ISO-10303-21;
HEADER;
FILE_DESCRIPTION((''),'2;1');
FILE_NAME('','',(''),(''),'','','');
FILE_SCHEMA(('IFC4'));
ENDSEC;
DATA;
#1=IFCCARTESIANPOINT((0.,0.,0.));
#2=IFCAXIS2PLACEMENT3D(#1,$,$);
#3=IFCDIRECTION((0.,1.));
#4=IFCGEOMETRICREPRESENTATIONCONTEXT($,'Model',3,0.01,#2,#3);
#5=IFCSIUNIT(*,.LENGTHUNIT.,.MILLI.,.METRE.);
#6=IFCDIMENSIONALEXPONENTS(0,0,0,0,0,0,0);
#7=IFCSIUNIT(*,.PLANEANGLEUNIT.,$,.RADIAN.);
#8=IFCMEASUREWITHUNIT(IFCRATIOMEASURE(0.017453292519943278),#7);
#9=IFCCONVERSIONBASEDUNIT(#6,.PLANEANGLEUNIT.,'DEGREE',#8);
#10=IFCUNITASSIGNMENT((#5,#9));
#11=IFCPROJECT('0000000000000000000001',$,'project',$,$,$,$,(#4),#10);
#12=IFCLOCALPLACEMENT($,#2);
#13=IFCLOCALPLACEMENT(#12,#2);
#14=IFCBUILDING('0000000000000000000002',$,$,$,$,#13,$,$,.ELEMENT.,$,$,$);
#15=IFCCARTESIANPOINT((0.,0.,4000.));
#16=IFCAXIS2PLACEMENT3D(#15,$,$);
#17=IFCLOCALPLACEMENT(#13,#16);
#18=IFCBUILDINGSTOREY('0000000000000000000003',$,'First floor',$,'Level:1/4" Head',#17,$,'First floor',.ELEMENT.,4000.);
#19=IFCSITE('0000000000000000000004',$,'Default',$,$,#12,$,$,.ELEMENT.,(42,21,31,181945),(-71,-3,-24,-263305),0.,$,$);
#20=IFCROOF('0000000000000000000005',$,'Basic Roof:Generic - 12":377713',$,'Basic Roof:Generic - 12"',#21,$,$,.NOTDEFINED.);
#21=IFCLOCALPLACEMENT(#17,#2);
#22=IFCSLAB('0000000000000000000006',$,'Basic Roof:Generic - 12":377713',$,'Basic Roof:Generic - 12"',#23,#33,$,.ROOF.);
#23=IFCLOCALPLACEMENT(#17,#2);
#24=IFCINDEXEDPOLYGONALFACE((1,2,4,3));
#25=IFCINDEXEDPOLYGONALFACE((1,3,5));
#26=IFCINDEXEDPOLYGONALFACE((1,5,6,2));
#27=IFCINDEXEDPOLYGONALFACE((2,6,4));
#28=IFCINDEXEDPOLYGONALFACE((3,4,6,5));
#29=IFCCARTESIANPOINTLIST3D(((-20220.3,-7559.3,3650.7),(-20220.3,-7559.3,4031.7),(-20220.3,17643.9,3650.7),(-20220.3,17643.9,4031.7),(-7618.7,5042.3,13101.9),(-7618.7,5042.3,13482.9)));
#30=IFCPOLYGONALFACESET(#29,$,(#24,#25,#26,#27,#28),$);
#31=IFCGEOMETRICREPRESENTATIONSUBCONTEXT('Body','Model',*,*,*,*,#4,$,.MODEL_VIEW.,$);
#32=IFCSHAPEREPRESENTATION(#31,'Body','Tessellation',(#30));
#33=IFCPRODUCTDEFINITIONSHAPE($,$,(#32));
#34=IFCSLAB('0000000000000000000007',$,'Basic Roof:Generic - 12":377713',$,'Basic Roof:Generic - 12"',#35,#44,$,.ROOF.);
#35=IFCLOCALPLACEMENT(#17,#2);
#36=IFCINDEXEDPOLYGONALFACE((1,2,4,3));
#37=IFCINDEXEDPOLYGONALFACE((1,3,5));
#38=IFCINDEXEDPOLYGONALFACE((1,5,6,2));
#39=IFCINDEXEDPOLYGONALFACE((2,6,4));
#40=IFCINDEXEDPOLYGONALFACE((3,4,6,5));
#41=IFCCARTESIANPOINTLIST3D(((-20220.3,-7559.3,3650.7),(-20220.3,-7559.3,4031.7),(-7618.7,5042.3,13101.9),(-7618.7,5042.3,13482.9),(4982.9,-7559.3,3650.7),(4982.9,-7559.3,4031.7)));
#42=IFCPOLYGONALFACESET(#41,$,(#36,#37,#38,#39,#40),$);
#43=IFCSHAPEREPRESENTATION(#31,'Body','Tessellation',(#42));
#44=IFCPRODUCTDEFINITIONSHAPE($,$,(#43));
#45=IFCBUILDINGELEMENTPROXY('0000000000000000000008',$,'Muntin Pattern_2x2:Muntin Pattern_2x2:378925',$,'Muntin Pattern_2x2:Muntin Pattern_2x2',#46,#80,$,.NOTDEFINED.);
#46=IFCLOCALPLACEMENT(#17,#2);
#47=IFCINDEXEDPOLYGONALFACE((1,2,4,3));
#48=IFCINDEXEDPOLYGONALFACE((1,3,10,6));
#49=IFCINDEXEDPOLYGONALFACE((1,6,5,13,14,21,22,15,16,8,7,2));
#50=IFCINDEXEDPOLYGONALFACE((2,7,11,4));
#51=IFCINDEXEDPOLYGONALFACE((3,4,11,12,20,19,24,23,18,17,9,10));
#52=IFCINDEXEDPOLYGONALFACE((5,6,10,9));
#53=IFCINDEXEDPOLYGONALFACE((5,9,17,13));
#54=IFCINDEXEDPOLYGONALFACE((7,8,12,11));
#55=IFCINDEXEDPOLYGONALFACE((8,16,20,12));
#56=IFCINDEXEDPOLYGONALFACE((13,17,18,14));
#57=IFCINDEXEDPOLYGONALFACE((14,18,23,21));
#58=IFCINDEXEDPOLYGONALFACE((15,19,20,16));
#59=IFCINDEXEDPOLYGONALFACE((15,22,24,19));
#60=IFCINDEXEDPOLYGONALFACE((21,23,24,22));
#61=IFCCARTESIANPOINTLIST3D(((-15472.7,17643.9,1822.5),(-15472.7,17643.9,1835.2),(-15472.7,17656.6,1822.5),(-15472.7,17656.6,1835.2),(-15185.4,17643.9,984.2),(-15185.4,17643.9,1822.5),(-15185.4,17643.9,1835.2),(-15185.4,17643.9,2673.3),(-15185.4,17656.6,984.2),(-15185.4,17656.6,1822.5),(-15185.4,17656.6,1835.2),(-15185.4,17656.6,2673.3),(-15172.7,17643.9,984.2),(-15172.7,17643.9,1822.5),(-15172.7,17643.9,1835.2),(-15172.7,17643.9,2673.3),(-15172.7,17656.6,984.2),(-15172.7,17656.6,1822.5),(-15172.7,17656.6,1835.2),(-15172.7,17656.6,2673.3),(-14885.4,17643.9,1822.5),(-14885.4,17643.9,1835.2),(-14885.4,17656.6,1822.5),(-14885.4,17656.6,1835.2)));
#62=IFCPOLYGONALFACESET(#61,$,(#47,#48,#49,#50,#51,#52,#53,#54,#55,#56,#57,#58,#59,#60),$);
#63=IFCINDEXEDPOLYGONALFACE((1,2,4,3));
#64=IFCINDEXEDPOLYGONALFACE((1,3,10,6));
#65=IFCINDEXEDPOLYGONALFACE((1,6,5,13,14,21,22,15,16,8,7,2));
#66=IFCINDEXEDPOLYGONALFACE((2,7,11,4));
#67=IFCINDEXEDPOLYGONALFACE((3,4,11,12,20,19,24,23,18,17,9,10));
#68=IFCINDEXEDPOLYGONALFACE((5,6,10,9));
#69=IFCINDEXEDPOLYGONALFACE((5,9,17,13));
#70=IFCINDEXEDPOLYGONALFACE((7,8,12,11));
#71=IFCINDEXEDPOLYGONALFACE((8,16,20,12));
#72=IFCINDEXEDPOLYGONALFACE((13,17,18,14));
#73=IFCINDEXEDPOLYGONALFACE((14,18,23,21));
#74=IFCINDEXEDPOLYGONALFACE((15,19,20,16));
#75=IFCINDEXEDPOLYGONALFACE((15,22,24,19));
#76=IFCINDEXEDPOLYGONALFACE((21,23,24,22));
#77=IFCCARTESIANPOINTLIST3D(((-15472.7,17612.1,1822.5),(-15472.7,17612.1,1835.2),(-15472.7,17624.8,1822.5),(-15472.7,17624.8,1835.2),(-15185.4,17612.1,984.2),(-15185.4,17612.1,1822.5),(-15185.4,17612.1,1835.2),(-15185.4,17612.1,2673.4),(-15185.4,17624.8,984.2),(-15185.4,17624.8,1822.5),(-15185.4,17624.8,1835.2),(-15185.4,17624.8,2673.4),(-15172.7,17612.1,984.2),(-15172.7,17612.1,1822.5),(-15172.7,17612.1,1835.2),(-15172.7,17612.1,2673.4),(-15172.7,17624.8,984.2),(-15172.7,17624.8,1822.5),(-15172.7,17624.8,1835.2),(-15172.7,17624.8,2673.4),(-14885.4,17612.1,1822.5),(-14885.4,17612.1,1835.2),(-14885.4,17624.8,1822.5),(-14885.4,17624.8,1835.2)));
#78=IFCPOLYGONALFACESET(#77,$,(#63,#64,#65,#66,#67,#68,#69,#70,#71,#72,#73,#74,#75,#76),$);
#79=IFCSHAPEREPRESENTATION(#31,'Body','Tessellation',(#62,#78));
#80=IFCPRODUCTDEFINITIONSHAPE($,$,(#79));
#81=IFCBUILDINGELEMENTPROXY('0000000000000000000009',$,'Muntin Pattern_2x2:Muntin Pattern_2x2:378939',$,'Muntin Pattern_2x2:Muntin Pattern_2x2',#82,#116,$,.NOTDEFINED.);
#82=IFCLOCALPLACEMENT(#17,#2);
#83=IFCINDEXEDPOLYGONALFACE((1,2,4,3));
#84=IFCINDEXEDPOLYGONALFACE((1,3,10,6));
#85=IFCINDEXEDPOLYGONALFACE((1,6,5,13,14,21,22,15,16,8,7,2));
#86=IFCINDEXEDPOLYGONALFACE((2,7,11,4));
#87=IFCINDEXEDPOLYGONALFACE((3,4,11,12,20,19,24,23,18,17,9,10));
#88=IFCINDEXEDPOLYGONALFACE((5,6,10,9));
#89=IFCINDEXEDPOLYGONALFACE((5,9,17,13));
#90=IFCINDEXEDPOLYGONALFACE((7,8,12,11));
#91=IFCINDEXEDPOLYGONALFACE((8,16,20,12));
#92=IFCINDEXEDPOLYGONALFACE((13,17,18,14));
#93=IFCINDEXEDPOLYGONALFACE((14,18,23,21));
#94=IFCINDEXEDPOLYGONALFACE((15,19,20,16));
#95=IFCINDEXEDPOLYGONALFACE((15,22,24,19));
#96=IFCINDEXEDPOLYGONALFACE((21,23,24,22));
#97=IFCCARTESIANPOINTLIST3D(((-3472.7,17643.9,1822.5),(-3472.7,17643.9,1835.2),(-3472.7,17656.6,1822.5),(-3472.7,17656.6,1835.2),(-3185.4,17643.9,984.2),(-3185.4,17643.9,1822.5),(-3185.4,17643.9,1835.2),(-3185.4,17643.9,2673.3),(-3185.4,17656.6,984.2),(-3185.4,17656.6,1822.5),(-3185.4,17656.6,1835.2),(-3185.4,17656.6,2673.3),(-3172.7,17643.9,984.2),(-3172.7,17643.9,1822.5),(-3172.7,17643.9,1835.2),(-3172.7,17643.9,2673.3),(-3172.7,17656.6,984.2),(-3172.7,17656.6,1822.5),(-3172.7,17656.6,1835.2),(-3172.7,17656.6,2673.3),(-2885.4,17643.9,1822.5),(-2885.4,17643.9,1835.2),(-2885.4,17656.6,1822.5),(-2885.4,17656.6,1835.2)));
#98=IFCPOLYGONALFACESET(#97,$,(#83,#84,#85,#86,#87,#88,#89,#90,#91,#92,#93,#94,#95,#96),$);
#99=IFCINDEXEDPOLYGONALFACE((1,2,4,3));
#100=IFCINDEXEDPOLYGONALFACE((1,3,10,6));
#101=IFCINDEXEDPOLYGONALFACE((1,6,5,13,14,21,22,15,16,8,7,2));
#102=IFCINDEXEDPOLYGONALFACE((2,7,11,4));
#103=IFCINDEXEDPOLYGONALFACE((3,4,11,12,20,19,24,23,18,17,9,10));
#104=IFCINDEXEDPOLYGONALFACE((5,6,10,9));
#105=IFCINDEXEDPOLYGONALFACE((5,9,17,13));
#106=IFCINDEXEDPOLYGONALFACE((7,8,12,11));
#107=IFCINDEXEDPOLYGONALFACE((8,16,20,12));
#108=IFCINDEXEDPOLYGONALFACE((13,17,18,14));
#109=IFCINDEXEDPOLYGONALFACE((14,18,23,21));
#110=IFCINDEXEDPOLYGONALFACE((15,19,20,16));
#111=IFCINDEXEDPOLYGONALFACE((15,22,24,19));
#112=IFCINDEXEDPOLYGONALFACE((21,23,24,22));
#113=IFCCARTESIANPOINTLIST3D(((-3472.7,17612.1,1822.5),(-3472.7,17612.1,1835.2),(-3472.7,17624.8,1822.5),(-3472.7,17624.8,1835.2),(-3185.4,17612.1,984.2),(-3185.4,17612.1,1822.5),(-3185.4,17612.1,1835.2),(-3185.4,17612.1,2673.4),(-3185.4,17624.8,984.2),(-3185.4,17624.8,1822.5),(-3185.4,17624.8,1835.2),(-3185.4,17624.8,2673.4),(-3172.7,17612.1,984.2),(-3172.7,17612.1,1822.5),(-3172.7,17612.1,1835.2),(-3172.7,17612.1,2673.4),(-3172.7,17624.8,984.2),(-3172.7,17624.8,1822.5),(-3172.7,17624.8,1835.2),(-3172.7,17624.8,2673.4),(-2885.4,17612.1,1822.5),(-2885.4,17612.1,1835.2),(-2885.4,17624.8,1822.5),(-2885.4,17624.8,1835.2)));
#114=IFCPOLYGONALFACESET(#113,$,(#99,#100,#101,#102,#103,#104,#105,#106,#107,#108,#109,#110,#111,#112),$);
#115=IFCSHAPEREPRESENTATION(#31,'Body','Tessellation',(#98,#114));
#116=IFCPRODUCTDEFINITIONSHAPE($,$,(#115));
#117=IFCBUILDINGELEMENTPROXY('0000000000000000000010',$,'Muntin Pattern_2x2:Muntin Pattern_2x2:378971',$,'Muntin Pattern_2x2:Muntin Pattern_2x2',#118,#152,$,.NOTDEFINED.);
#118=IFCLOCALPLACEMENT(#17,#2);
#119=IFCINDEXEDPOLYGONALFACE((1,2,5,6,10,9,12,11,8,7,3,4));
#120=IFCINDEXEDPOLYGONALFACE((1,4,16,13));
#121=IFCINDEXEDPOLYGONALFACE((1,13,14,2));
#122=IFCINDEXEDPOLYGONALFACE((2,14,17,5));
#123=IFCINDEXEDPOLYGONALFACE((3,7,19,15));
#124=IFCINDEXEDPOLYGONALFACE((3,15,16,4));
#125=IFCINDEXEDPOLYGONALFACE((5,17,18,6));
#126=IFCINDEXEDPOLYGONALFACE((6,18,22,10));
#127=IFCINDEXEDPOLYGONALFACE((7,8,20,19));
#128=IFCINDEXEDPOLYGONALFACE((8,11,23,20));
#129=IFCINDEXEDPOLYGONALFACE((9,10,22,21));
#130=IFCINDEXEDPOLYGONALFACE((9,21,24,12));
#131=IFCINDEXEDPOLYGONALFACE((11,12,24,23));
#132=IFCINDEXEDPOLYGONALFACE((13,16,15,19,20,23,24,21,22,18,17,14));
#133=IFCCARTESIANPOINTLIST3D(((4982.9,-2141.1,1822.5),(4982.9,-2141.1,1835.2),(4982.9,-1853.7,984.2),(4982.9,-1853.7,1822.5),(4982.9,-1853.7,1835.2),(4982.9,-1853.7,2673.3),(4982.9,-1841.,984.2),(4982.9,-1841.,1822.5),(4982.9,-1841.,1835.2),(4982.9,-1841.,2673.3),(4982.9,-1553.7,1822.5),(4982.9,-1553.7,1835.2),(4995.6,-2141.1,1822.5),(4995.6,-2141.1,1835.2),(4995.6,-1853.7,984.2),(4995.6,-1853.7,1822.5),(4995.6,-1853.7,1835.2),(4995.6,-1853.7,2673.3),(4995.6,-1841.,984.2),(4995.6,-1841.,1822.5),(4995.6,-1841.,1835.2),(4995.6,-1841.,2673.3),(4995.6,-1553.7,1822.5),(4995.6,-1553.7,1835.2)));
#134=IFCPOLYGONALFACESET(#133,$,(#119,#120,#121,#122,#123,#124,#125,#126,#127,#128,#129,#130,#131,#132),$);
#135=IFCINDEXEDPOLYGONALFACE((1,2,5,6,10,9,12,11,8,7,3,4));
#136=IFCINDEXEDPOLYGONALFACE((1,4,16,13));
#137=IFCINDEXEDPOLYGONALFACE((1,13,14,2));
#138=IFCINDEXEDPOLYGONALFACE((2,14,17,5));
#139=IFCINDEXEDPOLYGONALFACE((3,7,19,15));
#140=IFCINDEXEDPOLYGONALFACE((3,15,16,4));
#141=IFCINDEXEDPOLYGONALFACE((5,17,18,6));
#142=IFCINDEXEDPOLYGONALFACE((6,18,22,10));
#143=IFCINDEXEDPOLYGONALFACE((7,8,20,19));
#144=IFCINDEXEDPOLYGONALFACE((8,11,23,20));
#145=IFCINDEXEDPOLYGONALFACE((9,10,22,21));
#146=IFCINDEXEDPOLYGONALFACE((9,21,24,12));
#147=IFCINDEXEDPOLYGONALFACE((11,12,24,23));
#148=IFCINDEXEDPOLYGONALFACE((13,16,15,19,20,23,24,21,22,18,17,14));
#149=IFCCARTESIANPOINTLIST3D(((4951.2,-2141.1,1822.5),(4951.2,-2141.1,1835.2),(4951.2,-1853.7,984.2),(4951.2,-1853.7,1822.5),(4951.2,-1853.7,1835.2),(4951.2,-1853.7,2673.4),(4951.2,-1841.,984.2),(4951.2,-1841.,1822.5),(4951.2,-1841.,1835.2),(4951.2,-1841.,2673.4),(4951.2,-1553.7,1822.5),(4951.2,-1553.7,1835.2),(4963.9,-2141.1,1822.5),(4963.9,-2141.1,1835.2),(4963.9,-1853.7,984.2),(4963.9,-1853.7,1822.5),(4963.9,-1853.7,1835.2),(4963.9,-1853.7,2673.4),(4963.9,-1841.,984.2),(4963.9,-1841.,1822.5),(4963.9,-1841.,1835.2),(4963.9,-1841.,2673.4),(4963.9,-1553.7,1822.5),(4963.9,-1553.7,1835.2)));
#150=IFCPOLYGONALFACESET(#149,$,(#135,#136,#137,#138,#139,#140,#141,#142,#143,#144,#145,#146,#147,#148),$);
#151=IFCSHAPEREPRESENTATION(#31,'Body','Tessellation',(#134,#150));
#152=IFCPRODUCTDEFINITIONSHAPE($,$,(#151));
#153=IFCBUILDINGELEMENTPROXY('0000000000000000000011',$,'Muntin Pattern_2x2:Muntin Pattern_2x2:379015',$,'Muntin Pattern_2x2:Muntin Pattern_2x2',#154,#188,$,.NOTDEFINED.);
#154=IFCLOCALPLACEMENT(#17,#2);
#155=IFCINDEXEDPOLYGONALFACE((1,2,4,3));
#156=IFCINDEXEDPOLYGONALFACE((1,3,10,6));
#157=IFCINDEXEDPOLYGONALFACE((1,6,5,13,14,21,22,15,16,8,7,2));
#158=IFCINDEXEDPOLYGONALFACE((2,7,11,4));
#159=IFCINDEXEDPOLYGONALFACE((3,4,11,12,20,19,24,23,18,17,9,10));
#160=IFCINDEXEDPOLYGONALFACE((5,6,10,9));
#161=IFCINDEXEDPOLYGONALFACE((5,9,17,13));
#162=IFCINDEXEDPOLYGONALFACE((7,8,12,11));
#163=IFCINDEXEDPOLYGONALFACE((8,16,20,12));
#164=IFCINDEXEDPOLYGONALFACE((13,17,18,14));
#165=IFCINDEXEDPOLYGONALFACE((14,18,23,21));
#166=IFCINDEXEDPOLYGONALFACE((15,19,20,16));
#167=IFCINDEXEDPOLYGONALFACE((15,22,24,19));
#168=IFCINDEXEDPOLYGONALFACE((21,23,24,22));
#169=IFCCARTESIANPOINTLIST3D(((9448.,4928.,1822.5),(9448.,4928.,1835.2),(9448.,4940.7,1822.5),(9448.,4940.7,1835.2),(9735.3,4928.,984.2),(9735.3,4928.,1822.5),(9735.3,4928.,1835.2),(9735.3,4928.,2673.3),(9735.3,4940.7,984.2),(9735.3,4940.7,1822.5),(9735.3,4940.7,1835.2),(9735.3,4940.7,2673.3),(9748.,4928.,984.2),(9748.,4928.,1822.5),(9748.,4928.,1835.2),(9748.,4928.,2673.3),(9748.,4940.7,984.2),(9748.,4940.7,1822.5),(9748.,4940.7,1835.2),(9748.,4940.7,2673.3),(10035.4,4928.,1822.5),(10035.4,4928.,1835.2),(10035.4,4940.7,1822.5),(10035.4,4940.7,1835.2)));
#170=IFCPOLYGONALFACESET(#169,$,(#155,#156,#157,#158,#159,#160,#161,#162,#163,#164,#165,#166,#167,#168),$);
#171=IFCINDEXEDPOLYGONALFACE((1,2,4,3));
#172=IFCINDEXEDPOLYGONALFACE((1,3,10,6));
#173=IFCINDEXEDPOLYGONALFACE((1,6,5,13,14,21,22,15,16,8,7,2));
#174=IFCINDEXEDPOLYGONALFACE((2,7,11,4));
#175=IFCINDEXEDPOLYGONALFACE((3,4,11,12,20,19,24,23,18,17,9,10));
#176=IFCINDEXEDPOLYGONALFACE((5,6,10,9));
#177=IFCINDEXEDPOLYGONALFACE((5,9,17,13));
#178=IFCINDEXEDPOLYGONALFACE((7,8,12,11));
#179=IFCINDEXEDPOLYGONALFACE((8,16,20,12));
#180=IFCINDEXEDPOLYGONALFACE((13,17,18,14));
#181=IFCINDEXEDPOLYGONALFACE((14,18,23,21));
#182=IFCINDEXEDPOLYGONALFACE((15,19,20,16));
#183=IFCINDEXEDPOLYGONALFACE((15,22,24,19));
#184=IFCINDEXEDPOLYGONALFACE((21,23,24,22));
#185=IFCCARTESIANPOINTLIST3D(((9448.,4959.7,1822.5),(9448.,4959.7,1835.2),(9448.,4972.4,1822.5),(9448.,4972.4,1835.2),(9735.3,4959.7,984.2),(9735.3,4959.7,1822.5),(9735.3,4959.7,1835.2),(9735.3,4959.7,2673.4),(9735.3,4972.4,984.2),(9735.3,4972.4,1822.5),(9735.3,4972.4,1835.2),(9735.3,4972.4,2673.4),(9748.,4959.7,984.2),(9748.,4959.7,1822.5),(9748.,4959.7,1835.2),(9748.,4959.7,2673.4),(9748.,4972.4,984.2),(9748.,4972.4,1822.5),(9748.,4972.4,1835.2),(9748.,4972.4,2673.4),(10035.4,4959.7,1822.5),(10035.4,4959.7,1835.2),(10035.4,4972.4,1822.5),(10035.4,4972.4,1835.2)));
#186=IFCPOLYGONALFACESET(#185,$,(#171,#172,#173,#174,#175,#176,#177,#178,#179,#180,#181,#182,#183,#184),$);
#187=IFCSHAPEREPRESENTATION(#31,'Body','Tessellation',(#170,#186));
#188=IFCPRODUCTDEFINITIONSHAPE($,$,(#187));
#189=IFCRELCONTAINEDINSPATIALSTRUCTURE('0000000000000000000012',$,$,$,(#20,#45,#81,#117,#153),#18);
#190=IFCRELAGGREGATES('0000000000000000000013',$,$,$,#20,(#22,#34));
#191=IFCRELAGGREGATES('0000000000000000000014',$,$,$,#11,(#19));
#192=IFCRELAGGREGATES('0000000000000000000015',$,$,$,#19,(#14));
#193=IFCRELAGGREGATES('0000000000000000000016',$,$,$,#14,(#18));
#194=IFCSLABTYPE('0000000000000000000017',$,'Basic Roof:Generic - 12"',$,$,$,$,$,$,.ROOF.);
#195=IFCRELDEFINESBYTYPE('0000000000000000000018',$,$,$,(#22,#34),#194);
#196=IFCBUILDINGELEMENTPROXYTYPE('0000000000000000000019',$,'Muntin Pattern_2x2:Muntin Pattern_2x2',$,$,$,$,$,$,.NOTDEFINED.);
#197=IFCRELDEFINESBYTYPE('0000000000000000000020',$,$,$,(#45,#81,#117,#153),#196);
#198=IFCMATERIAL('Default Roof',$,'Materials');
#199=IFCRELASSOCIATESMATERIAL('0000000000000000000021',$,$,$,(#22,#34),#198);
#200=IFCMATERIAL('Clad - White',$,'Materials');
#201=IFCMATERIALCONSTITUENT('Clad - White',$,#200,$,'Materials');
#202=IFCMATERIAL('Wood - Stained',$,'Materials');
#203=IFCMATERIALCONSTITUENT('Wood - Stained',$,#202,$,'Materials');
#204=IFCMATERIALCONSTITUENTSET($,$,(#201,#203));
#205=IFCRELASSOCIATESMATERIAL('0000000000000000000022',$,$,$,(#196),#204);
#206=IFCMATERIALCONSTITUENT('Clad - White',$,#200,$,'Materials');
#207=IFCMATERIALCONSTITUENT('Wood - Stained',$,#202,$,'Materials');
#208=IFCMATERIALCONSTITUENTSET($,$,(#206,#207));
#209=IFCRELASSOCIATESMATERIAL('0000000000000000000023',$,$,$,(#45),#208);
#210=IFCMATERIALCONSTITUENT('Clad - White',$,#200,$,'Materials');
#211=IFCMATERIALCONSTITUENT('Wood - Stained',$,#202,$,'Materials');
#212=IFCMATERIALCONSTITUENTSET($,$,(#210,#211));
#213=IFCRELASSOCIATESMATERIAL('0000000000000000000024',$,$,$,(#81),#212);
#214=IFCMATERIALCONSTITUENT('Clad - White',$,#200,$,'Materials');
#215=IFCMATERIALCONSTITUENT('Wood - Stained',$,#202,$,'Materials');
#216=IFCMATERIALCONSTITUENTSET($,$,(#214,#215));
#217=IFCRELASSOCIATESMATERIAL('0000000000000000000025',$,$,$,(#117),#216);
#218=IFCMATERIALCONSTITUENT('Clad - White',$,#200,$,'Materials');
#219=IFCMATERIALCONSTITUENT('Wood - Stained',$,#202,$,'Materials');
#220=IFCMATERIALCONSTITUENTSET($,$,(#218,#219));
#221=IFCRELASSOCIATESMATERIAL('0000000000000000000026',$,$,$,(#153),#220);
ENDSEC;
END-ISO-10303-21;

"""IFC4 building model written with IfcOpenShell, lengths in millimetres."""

from ifc_helpers import new_model, entity, si_unit, converted_unit, direction, frame, origin, place, context, subcontext, project, spatial, indexed_curve, outline, extrude, source, transform, mapped, material, constituent, constituent_set, type_object, type_shapes, element, aggregate, save


model = new_model("IFC4")

# Units and contexts
model_context = context("Model", 3, precision=0.01, world=origin(), true_north=direction((0.0, 1.0)))
body_context = subcontext(model_context, "Body", "Model", "MODEL_VIEW")
ifc_project = project(units=[si_unit("LENGTHUNIT", "METRE", prefix="MILLI"), converted_unit("PLANEANGLEUNIT", "DEGREE", entity("IfcRatioMeasure", 0.017453292519943278), si_unit("PLANEANGLEUNIT", "RADIAN"), dimensions=[0, 0, 0, 0, 0, 0, 0])], contexts=[model_context])

# Site, building, storey
site_placement = place(None, origin())
site = spatial("IfcSite", under=ifc_project, at=site_placement, Name="Default", CompositionType="ELEMENT", RefLatitude=(42, 21, 31, 181945), RefLongitude=(-71, -3, -24, -263305), RefElevation=0.0)
building_placement = place(site_placement, origin())
building = spatial("IfcBuilding", under=site, at=building_placement, CompositionType="ELEMENT")
storey_placement = place(building_placement, frame((0.0, 0.0, 4000.0)))
storey = spatial("IfcBuildingStorey", under=building, at=storey_placement, Name="First floor", ObjectType="Level:1/4\" Head", LongName="First floor", CompositionType="ELEMENT", Elevation=4000.0)

# Roof, slabs
roof_placement = place(storey_placement, frame((-20220.3, -7559.3, 3650.7)))
roof = element("IfcRoof", 1, at=roof_placement, inside=storey, Name="Basic Roof:Generic - 12\":377713", ObjectType="Basic Roof:Generic - 12\"", PredefinedType="NOTDEFINED")
ifc_material_1 = material(Name="Default Roof", Category="Materials")
slab_type_1 = type_object("IfcSlabType", Name="Basic Roof:Generic - 12\"", PredefinedType="ROOF")
slab_1_placement = place(roof_placement, origin())
slab_1 = element("IfcSlab", 2, at=slab_1_placement, type_object=slab_type_1, material=ifc_material_1, Name="Basic Roof:Generic - 12\":377713", ObjectType="Basic Roof:Generic - 12\"", PredefinedType="ROOF", context=body_context, shape_type="SweptSolid", body=[
    extrude(outline(indexed_curve([(7876.0, 0.0), (-7876.0, 12601.6), (-7876.0, -12601.6), (7876.0, 0.0)], self_intersect=False)), frame((6300.8, 12601.6, 4725.6), z_axis=(-0.6, 0.0, 0.8), x_axis=(0.8, 0.0, 0.6)), (0.6, 0.0, 0.8), 381.0),
])
slab_2_placement = place(roof_placement, origin())
slab_2 = element("IfcSlab", 3, at=slab_2_placement, type_object=slab_type_1, material=ifc_material_1, Name="Basic Roof:Generic - 12\":377713", ObjectType="Basic Roof:Generic - 12\"", PredefinedType="ROOF", context=body_context, shape_type="SweptSolid", body=[
    extrude(outline(indexed_curve([(-12601.6, -7876.0), (12601.6, -7876.0), (0.0, 7876.0), (-12601.6, -7876.0)], self_intersect=False)), frame((12601.6, 6300.8, 4725.6), z_axis=(0.0, -0.6, 0.8), x_axis=(1.0, 0.0, 0.0)), (0.0, 0.6, 0.8), 381.0),
])
aggregate(roof, [slab_1, slab_2])

# Building element proxies
ifc_material_2 = material(Name="Clad - White", Category="Materials")
ifc_constituent_1 = constituent(ifc_material_2, Name="Clad - White", Category="Materials")
ifc_material_3 = material(Name="Wood - Stained", Category="Materials")
ifc_constituent_2 = constituent(ifc_material_3, Name="Wood - Stained", Category="Materials")
ifc_constituent_set_1 = constituent_set(constituents=[ifc_constituent_1, ifc_constituent_2])
ifc_constituent_3 = constituent(ifc_material_2, Name="Clad - White", Category="Materials")
ifc_constituent_4 = constituent(ifc_material_3, Name="Wood - Stained", Category="Materials")
ifc_constituent_set_2 = constituent_set(constituents=[ifc_constituent_3, ifc_constituent_4])
building_element_proxy_type_1 = type_object("IfcBuildingElementProxyType", Name="Muntin Pattern_2x2:Muntin Pattern_2x2", PredefinedType="NOTDEFINED", material=ifc_constituent_set_2)
shared_shape_1 = source(origin(), body_context, "Body", "SweptSolid", [
    extrude(outline(indexed_curve([(6.4, -6.4), (844.5, -6.4), (844.5, 6.3), (6.4, 6.3), (6.4, 293.7), (-6.3, 293.7), (-6.3, 6.3), (-844.6, 6.3), (-844.6, -6.4), (-6.3, -6.4), (-6.3, -293.7), (6.4, -293.7), (6.4, -6.4)], self_intersect=False)), frame((0.0, 9.5, 844.5), z_axis=(0.0, 1.0, 0.0), x_axis=(0.0, 0.0, 1.0)), (0.0, 0.0, 1.0), 12.7),
    extrude(outline(indexed_curve([(6.4, -6.4), (844.6, -6.4), (844.6, 6.3), (6.4, 6.3), (6.4, 293.7), (-6.3, 293.7), (-6.3, 6.3), (-844.6, 6.3), (-844.6, -6.4), (-6.3, -6.4), (-6.3, -293.7), (6.4, -293.7), (6.4, -6.4)], self_intersect=False)), frame((0.0, -22.2, 844.6), z_axis=(0.0, 1.0, 0.0), x_axis=(0.0, 0.0, 1.0)), (0.0, 0.0, 1.0), 12.7),
])
type_shapes(building_element_proxy_type_1, [shared_shape_1])
proxy_1_placement = place(storey_placement, frame((-15179.1, 17634.3, 984.3)))
element("IfcBuildingElementProxy", 4, at=proxy_1_placement, inside=storey, type_object=building_element_proxy_type_1, material=ifc_constituent_set_1, Name="Muntin Pattern_2x2:Muntin Pattern_2x2:378925", ObjectType="Muntin Pattern_2x2:Muntin Pattern_2x2", PredefinedType="NOTDEFINED", context=body_context, shape_type="MappedRepresentation", body=[
    mapped(shared_shape_1, transform((0.0, 0.0, 0.0), scale=1.0)),
])
ifc_constituent_5 = constituent(ifc_material_2, Name="Clad - White", Category="Materials")
ifc_constituent_6 = constituent(ifc_material_3, Name="Wood - Stained", Category="Materials")
ifc_constituent_set_3 = constituent_set(constituents=[ifc_constituent_5, ifc_constituent_6])
proxy_2_placement = place(storey_placement, frame((-3179.1, 17634.3, 984.3)))
element("IfcBuildingElementProxy", 5, at=proxy_2_placement, inside=storey, type_object=building_element_proxy_type_1, material=ifc_constituent_set_3, Name="Muntin Pattern_2x2:Muntin Pattern_2x2:378939", ObjectType="Muntin Pattern_2x2:Muntin Pattern_2x2", PredefinedType="NOTDEFINED", context=body_context, shape_type="MappedRepresentation", body=[
    mapped(shared_shape_1, transform((0.0, 0.0, 0.0), scale=1.0)),
])
ifc_constituent_7 = constituent(ifc_material_2, Name="Clad - White", Category="Materials")
ifc_constituent_8 = constituent(ifc_material_3, Name="Wood - Stained", Category="Materials")
ifc_constituent_set_4 = constituent_set(constituents=[ifc_constituent_7, ifc_constituent_8])
proxy_3_placement = place(storey_placement, frame((4973.4, -1847.4, 984.3), z_axis=(0.0, 0.0, 1.0), x_axis=(0.0, -1.0, 0.0)))
element("IfcBuildingElementProxy", 6, at=proxy_3_placement, inside=storey, type_object=building_element_proxy_type_1, material=ifc_constituent_set_4, Name="Muntin Pattern_2x2:Muntin Pattern_2x2:378971", ObjectType="Muntin Pattern_2x2:Muntin Pattern_2x2", PredefinedType="NOTDEFINED", context=body_context, shape_type="MappedRepresentation", body=[
    mapped(shared_shape_1, transform((0.0, 0.0, 0.0), scale=1.0)),
])
ifc_constituent_9 = constituent(ifc_material_2, Name="Clad - White", Category="Materials")
ifc_constituent_10 = constituent(ifc_material_3, Name="Wood - Stained", Category="Materials")
ifc_constituent_set_5 = constituent_set(constituents=[ifc_constituent_9, ifc_constituent_10])
proxy_4_placement = place(storey_placement, frame((9741.7, 4950.2, 984.3), z_axis=(0.0, 0.0, 1.0), x_axis=(-1.0, 0.0, 0.0)))
element("IfcBuildingElementProxy", 7, at=proxy_4_placement, inside=storey, type_object=building_element_proxy_type_1, material=ifc_constituent_set_5, Name="Muntin Pattern_2x2:Muntin Pattern_2x2:379015", ObjectType="Muntin Pattern_2x2:Muntin Pattern_2x2", PredefinedType="NOTDEFINED", context=body_context, shape_type="MappedRepresentation", body=[
    mapped(shared_shape_1, transform((0.0, 0.0, 0.0), scale=1.0)),
])

save(model, "model.ifc")
